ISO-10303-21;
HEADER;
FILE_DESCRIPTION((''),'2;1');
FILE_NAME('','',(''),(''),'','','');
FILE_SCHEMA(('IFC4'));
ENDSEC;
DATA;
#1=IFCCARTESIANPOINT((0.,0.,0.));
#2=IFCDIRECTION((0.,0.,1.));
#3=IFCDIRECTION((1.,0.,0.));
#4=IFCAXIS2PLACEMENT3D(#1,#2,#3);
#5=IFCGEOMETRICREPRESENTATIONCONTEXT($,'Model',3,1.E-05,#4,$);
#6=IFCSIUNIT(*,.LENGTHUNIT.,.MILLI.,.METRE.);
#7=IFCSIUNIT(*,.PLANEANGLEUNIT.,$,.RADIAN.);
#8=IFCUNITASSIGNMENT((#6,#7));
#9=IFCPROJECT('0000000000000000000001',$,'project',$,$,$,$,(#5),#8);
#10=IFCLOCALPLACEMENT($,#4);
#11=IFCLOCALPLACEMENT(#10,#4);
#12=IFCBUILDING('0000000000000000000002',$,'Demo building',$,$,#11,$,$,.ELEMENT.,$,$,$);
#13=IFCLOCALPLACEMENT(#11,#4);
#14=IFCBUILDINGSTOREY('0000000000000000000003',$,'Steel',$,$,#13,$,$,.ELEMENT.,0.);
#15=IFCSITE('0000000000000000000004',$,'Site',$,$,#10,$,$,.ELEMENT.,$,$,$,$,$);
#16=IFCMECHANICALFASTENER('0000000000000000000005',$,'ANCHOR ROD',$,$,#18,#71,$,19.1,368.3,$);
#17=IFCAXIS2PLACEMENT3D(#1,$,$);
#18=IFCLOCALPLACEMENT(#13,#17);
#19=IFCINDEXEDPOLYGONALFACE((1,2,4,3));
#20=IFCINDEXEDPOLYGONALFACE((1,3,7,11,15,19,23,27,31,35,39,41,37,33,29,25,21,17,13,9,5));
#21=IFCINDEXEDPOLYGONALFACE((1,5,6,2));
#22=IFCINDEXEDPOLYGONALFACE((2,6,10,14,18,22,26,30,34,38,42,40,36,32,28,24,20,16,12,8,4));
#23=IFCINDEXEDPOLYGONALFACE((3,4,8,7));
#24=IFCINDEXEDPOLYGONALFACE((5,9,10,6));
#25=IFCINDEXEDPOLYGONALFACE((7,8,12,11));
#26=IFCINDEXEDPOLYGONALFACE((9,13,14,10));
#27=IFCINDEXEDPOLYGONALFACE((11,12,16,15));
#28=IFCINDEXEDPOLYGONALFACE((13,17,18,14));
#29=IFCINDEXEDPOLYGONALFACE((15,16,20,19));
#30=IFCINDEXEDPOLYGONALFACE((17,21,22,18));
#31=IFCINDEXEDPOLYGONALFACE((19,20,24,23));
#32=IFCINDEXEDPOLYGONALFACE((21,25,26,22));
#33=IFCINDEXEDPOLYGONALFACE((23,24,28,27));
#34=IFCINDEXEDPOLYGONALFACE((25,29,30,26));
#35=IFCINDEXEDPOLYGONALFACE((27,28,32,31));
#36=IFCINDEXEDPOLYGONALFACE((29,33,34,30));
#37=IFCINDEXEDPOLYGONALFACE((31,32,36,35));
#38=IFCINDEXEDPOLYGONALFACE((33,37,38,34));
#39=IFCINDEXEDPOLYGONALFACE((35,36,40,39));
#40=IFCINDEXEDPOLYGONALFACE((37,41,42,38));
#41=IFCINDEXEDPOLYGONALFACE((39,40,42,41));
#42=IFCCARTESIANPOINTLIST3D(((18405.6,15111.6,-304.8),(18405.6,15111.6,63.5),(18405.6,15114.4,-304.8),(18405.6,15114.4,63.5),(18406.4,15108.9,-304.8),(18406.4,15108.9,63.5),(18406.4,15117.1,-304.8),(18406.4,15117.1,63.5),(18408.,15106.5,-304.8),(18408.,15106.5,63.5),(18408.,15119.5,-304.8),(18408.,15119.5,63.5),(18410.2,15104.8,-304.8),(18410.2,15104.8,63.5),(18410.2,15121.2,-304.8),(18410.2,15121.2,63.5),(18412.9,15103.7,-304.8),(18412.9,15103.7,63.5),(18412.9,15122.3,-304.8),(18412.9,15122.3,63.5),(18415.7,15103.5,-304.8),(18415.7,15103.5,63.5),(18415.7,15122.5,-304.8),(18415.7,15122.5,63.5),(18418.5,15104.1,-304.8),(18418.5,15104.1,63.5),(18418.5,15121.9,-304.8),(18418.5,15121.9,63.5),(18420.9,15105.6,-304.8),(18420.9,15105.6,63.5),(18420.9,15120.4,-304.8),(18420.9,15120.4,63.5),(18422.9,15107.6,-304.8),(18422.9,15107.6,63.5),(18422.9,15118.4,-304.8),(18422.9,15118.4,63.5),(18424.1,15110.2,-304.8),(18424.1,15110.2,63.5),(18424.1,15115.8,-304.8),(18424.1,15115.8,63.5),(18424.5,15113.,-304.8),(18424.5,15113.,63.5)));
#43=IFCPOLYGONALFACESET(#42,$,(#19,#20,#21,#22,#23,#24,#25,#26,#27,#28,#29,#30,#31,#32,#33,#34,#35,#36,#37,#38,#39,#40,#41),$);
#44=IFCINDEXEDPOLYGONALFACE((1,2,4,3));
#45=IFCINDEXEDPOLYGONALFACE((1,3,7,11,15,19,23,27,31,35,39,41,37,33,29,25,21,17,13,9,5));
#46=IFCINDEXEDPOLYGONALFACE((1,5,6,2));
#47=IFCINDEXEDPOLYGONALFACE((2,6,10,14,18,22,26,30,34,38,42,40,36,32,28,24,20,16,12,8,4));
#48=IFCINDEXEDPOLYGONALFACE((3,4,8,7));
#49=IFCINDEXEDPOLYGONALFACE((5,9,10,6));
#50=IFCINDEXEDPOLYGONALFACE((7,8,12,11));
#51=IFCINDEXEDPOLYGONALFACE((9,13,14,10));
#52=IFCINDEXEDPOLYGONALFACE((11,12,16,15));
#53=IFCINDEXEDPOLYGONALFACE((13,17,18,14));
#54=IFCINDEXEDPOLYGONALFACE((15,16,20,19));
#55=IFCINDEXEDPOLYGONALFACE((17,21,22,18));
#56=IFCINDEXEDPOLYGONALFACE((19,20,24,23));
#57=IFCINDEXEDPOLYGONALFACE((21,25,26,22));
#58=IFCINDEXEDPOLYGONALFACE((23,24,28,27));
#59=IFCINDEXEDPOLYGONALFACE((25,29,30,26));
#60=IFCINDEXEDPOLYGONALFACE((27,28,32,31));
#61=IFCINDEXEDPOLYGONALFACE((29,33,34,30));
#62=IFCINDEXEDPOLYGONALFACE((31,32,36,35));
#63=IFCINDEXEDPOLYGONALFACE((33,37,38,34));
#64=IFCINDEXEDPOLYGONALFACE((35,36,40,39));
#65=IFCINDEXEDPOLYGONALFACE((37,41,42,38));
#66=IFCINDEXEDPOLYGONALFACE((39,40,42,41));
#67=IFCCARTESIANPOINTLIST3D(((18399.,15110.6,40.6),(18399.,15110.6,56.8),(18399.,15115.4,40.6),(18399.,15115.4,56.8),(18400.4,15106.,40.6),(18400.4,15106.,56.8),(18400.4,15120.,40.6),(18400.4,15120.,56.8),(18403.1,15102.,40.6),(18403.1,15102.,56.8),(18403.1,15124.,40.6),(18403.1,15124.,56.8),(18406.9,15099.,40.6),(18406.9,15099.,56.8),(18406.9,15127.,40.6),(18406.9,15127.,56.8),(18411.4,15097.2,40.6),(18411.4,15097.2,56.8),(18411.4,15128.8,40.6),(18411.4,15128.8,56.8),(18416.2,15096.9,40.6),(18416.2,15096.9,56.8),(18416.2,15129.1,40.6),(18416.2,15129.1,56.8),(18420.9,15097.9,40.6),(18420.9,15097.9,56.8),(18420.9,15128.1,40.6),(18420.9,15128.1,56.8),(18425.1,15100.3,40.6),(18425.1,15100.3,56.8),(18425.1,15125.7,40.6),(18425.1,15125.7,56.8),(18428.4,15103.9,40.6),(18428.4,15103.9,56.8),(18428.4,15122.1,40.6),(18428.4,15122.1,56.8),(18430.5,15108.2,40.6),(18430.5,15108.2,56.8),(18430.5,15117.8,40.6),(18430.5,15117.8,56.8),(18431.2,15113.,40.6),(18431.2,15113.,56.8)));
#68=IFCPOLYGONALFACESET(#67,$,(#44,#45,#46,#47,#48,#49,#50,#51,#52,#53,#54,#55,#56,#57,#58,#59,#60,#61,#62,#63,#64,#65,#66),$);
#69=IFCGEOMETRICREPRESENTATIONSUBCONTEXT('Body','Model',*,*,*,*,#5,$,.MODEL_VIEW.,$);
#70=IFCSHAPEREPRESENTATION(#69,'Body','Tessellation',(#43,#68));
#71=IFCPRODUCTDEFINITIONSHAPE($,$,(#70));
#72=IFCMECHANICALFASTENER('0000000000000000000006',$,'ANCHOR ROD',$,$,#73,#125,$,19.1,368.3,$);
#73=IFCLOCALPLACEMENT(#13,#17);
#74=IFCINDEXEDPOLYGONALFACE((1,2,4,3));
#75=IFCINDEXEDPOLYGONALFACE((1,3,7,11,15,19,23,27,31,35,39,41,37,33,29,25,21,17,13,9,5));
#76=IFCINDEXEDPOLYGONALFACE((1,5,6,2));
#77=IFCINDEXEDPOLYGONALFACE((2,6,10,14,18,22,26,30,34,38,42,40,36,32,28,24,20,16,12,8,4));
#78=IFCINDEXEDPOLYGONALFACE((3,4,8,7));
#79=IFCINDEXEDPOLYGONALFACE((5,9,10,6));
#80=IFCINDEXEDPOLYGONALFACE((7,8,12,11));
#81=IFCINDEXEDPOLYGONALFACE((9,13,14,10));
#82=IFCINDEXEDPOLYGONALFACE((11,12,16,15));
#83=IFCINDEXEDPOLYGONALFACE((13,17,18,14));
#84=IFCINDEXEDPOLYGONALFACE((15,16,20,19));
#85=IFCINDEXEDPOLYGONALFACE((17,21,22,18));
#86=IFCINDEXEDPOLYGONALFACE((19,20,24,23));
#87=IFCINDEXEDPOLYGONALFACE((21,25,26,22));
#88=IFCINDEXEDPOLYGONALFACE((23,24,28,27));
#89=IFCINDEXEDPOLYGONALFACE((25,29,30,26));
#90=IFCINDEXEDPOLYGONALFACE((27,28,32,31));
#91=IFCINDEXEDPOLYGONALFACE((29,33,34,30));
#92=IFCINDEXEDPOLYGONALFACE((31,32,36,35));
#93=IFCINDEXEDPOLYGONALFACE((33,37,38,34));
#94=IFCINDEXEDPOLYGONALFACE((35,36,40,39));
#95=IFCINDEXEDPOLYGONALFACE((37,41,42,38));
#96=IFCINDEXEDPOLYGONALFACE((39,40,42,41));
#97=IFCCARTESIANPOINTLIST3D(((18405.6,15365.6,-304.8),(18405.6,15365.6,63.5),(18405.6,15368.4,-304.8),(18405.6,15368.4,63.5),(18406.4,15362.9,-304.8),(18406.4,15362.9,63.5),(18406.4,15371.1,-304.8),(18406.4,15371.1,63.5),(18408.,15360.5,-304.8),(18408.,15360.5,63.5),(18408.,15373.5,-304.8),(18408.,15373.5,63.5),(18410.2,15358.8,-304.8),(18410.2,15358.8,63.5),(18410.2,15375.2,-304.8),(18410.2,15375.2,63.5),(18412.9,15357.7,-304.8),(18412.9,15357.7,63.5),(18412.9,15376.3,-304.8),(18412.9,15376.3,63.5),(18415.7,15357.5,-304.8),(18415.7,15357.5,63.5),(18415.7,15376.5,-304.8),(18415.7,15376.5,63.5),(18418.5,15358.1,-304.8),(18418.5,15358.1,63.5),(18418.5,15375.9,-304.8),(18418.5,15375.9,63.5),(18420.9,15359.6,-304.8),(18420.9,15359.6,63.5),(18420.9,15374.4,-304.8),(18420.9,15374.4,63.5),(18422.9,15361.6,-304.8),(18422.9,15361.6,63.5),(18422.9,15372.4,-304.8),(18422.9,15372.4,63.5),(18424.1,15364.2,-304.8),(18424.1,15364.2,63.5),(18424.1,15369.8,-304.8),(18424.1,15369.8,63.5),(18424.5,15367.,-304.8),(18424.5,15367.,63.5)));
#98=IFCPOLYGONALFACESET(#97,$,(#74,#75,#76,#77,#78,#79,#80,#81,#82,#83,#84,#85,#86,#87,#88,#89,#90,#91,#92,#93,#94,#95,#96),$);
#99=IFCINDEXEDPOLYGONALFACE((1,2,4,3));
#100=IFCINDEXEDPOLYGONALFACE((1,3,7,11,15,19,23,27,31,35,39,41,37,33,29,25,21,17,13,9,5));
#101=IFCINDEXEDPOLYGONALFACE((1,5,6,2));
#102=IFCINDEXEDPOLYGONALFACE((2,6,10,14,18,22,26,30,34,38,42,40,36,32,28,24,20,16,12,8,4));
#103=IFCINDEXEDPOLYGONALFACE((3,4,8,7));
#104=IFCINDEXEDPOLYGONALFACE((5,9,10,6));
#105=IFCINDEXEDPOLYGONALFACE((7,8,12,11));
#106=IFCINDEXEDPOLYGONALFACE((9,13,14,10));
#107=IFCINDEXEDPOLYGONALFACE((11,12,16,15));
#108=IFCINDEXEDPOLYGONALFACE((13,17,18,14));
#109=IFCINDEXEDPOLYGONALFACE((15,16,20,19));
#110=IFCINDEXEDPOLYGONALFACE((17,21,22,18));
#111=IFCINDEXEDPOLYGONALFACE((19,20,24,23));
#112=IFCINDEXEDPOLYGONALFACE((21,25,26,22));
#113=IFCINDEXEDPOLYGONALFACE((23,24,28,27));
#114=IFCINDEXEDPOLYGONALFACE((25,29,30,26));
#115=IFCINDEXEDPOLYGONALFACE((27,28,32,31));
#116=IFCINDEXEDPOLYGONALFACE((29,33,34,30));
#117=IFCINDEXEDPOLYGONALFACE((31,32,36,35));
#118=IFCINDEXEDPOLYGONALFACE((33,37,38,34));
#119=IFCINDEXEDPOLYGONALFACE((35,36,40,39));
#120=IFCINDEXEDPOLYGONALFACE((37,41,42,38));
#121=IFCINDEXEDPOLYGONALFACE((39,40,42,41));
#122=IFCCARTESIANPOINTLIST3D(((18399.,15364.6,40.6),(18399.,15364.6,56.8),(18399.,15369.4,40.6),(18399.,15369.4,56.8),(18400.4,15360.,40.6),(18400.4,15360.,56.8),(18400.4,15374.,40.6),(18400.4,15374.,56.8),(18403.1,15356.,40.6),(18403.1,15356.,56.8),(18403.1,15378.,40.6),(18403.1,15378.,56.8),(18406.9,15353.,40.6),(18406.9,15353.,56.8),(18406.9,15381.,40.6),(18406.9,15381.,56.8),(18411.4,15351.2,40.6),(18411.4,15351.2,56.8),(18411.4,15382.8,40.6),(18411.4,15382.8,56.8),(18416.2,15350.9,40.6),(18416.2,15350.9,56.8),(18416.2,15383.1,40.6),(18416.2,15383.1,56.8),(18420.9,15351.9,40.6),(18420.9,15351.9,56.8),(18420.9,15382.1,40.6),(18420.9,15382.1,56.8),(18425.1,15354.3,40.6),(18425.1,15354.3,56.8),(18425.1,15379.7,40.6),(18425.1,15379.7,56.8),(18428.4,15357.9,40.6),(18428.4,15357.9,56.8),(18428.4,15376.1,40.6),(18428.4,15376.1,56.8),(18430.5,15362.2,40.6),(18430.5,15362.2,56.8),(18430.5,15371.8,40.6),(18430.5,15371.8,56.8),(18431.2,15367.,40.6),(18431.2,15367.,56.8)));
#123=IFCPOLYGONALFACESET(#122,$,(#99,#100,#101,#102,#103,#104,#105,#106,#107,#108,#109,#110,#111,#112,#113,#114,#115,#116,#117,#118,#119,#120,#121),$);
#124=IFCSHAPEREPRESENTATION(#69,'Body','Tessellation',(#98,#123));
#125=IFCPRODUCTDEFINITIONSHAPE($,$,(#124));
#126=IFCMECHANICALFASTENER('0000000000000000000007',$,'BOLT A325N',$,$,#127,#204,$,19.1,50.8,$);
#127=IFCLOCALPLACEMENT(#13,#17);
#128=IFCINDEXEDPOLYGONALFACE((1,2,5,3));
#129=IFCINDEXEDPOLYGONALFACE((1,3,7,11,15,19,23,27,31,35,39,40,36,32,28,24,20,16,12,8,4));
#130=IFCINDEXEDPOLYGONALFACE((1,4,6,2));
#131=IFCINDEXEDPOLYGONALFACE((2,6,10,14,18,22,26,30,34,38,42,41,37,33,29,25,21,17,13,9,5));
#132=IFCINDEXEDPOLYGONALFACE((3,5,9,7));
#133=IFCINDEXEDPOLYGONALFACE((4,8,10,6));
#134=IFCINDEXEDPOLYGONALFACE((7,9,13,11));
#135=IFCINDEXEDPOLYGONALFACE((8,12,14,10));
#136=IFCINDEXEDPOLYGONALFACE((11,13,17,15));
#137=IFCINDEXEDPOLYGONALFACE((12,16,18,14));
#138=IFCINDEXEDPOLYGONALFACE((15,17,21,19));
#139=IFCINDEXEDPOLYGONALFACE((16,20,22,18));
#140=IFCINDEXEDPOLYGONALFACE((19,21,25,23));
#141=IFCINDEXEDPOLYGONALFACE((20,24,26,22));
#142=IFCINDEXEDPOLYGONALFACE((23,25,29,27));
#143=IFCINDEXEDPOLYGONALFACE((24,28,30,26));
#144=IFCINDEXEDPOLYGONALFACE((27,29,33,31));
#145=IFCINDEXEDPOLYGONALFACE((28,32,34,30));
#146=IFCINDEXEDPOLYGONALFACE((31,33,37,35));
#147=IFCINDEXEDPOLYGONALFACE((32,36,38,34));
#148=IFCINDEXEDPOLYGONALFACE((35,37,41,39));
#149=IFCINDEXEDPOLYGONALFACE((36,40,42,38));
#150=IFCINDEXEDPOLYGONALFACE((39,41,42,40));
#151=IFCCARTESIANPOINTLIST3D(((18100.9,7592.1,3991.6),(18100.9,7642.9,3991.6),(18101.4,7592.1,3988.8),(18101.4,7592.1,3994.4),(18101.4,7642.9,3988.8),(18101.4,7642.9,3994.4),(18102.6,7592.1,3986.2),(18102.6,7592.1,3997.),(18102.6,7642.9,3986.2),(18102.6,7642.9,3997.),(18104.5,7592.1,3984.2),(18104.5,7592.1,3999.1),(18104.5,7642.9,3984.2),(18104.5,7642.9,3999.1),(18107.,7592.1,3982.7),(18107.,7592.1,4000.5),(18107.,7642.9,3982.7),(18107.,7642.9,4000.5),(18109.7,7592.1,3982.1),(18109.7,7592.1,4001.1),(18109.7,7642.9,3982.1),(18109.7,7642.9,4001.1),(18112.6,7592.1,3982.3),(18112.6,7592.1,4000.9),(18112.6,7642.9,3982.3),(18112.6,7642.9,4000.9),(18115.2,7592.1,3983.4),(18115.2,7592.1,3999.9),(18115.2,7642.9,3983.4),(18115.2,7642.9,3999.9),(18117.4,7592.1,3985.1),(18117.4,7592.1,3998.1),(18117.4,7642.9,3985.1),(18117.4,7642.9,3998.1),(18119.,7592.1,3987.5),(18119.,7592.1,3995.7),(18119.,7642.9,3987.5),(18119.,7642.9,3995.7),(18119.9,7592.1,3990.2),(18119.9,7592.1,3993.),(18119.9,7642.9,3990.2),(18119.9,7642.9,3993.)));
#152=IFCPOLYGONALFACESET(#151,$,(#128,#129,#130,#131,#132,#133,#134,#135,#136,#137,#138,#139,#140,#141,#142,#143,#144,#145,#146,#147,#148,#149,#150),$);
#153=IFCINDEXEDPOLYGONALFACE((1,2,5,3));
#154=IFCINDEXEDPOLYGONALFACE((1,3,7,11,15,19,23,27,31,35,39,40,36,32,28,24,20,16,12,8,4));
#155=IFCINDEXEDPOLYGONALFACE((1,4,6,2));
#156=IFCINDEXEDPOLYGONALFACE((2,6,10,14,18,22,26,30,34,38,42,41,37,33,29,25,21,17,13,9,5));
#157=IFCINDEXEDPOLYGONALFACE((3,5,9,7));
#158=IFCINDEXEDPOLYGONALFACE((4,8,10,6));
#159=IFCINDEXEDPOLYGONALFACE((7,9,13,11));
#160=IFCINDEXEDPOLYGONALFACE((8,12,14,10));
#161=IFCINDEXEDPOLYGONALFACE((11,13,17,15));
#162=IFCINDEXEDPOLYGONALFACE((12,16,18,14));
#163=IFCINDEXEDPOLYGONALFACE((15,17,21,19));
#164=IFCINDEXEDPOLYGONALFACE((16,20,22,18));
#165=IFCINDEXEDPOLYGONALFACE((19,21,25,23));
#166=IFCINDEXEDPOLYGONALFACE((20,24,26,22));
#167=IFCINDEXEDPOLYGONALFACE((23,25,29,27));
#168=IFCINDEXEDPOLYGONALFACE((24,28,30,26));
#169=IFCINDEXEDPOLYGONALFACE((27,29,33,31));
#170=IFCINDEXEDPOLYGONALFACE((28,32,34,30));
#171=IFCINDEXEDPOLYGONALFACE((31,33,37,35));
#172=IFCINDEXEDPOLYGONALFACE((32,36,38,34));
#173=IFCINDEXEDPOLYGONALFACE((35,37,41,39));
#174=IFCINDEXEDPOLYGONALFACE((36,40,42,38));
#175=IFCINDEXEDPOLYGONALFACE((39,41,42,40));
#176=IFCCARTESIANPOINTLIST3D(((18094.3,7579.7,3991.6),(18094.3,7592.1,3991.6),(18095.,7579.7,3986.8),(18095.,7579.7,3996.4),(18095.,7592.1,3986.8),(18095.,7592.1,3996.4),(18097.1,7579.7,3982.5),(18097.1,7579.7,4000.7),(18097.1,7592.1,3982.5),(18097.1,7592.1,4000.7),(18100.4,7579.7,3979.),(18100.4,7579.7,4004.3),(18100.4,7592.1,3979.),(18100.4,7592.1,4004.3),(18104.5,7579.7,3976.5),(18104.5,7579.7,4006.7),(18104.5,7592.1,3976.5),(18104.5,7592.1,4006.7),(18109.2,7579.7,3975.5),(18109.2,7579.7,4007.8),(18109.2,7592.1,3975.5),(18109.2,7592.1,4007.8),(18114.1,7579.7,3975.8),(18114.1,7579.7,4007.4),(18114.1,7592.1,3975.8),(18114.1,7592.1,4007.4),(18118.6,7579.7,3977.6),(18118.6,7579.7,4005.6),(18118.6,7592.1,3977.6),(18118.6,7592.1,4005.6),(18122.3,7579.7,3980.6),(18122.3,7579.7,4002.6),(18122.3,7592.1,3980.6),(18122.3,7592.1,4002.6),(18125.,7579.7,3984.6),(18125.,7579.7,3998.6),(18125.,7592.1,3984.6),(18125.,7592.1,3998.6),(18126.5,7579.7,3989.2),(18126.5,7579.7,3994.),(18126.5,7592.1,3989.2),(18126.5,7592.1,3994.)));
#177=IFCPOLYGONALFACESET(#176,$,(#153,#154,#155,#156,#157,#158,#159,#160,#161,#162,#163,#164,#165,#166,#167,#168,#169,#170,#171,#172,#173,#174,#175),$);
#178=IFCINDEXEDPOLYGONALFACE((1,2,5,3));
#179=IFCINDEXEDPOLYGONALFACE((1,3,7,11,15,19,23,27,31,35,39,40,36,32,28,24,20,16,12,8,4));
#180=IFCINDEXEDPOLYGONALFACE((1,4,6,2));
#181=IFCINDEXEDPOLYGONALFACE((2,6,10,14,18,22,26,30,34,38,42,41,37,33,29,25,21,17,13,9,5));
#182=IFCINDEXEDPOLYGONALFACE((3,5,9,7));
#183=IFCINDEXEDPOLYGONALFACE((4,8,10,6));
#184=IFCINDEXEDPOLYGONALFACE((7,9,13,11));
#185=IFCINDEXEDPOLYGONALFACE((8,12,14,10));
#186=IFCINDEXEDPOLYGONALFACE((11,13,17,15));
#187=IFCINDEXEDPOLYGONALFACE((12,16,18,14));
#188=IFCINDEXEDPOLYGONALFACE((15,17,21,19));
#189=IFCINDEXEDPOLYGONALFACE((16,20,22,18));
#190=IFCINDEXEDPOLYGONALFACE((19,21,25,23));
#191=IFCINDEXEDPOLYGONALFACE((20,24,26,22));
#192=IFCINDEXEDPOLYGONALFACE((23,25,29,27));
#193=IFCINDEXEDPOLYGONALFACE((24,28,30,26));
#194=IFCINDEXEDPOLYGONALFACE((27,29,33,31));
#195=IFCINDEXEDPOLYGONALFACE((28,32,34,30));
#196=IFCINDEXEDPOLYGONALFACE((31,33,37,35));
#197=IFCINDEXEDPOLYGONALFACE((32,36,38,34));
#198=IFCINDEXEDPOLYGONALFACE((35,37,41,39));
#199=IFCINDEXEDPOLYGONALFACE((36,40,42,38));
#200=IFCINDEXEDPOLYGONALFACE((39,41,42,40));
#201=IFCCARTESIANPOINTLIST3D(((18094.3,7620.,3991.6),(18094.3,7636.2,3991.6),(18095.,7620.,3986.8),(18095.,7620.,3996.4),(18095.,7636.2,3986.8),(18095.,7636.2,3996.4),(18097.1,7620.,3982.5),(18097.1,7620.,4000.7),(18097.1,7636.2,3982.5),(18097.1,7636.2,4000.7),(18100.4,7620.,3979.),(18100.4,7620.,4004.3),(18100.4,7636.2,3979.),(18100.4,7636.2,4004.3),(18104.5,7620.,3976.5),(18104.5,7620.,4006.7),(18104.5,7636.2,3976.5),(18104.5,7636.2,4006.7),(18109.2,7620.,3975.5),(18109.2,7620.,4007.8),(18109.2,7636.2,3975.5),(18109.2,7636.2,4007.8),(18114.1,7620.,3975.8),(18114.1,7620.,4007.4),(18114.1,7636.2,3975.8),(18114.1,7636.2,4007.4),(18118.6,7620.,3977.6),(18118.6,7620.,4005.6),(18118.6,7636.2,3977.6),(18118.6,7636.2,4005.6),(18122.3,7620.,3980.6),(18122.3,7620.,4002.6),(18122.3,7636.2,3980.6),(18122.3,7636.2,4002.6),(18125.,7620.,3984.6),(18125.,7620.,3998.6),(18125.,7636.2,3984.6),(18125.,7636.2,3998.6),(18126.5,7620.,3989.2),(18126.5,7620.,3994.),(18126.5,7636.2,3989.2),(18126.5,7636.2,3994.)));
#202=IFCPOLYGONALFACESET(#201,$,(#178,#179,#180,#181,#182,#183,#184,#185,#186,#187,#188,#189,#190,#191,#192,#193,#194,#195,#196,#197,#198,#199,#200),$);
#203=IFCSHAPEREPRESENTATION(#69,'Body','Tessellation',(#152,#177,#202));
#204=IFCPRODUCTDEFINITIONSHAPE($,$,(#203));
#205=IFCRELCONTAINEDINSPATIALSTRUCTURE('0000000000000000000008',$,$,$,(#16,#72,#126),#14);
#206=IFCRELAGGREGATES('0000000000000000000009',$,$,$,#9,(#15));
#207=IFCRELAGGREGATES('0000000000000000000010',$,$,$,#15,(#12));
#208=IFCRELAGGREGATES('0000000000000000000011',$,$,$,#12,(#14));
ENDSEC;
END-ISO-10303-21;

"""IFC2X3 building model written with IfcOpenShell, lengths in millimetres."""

from ifc_helpers import new_model, si_unit, frame, origin, origin_with_axes, origin_2d, place, context, subcontext, project, spatial, circle, extrude, element, save


model = new_model("IFC2X3")

# Units and contexts
model_context = context("Model", 3, precision=1e-05, world=origin_with_axes())
body_context = subcontext(model_context, "Body", "Model", "MODEL_VIEW")
ifc_project = project(units=[si_unit("LENGTHUNIT", "METRE", prefix="MILLI"), si_unit("PLANEANGLEUNIT", "RADIAN")], contexts=[model_context])

# Site, building, storey
site_placement = place(None, origin_with_axes())
site = spatial("IfcSite", under=ifc_project, at=site_placement, Name="Site", CompositionType="ELEMENT")
building_placement = place(site_placement, origin_with_axes())
building = spatial("IfcBuilding", under=site, at=building_placement, Name="Demo building", CompositionType="ELEMENT")
placement = place(building_placement, origin_with_axes())
storey = spatial("IfcBuildingStorey", under=building, at=placement, Name="Steel", CompositionType="ELEMENT", Elevation=0.0)

# Mechanical fasteners
for number, where, z_axis, x_axis, name in (
    (1, (18415.0, 15113.0, -304.8), (0.0, 0.0, 1.0), (1.0, 0.0, 0.0), "ANCHOR ROD"),
    (2, (18415.0, 15367.0, -304.8), (0.0, 0.0, 1.0), (1.0, 0.0, 0.0), "ANCHOR ROD"),
):
    element("IfcMechanicalFastener", number, at=place(placement, frame(where, z_axis=z_axis, x_axis=x_axis)), inside=storey, Name=name, NominalDiameter=19.1, NominalLength=368.3, context=body_context, shape_type="SweptSolid", body=[
        extrude(circle(Radius=9.5, at=origin_2d()), origin(), (0.0, 0.0, 1.0), 368.3),
        extrude(circle(Radius=16.2, at=origin_2d()), frame((0.0, 0.0, 345.4)), (0.0, 0.0, 1.0), 16.2),
    ])
for number, where, z_axis, x_axis, name in (
    (3, (18110.5, 7592.1, 3991.6), (0.0, 1.0, 0.0), (-1.0, 0.0, 0.0), "BOLT A325N"),
):
    element("IfcMechanicalFastener", number, at=place(placement, frame(where, z_axis=z_axis, x_axis=x_axis)), inside=storey, Name=name, NominalDiameter=19.1, NominalLength=50.8, context=body_context, shape_type="SweptSolid", body=[
        extrude(circle(Radius=9.5, at=origin_2d()), origin(), (0.0, 0.0, 1.0), 50.8),
        extrude(circle(Radius=16.2, at=origin_2d()), frame((0.0, 0.0, -12.4)), (0.0, 0.0, 1.0), 12.4),
        extrude(circle(Radius=16.2, at=origin_2d()), frame((0.0, 0.0, 27.9)), (0.0, 0.0, 1.0), 16.2),
    ])

save(model, "model.ifc")
